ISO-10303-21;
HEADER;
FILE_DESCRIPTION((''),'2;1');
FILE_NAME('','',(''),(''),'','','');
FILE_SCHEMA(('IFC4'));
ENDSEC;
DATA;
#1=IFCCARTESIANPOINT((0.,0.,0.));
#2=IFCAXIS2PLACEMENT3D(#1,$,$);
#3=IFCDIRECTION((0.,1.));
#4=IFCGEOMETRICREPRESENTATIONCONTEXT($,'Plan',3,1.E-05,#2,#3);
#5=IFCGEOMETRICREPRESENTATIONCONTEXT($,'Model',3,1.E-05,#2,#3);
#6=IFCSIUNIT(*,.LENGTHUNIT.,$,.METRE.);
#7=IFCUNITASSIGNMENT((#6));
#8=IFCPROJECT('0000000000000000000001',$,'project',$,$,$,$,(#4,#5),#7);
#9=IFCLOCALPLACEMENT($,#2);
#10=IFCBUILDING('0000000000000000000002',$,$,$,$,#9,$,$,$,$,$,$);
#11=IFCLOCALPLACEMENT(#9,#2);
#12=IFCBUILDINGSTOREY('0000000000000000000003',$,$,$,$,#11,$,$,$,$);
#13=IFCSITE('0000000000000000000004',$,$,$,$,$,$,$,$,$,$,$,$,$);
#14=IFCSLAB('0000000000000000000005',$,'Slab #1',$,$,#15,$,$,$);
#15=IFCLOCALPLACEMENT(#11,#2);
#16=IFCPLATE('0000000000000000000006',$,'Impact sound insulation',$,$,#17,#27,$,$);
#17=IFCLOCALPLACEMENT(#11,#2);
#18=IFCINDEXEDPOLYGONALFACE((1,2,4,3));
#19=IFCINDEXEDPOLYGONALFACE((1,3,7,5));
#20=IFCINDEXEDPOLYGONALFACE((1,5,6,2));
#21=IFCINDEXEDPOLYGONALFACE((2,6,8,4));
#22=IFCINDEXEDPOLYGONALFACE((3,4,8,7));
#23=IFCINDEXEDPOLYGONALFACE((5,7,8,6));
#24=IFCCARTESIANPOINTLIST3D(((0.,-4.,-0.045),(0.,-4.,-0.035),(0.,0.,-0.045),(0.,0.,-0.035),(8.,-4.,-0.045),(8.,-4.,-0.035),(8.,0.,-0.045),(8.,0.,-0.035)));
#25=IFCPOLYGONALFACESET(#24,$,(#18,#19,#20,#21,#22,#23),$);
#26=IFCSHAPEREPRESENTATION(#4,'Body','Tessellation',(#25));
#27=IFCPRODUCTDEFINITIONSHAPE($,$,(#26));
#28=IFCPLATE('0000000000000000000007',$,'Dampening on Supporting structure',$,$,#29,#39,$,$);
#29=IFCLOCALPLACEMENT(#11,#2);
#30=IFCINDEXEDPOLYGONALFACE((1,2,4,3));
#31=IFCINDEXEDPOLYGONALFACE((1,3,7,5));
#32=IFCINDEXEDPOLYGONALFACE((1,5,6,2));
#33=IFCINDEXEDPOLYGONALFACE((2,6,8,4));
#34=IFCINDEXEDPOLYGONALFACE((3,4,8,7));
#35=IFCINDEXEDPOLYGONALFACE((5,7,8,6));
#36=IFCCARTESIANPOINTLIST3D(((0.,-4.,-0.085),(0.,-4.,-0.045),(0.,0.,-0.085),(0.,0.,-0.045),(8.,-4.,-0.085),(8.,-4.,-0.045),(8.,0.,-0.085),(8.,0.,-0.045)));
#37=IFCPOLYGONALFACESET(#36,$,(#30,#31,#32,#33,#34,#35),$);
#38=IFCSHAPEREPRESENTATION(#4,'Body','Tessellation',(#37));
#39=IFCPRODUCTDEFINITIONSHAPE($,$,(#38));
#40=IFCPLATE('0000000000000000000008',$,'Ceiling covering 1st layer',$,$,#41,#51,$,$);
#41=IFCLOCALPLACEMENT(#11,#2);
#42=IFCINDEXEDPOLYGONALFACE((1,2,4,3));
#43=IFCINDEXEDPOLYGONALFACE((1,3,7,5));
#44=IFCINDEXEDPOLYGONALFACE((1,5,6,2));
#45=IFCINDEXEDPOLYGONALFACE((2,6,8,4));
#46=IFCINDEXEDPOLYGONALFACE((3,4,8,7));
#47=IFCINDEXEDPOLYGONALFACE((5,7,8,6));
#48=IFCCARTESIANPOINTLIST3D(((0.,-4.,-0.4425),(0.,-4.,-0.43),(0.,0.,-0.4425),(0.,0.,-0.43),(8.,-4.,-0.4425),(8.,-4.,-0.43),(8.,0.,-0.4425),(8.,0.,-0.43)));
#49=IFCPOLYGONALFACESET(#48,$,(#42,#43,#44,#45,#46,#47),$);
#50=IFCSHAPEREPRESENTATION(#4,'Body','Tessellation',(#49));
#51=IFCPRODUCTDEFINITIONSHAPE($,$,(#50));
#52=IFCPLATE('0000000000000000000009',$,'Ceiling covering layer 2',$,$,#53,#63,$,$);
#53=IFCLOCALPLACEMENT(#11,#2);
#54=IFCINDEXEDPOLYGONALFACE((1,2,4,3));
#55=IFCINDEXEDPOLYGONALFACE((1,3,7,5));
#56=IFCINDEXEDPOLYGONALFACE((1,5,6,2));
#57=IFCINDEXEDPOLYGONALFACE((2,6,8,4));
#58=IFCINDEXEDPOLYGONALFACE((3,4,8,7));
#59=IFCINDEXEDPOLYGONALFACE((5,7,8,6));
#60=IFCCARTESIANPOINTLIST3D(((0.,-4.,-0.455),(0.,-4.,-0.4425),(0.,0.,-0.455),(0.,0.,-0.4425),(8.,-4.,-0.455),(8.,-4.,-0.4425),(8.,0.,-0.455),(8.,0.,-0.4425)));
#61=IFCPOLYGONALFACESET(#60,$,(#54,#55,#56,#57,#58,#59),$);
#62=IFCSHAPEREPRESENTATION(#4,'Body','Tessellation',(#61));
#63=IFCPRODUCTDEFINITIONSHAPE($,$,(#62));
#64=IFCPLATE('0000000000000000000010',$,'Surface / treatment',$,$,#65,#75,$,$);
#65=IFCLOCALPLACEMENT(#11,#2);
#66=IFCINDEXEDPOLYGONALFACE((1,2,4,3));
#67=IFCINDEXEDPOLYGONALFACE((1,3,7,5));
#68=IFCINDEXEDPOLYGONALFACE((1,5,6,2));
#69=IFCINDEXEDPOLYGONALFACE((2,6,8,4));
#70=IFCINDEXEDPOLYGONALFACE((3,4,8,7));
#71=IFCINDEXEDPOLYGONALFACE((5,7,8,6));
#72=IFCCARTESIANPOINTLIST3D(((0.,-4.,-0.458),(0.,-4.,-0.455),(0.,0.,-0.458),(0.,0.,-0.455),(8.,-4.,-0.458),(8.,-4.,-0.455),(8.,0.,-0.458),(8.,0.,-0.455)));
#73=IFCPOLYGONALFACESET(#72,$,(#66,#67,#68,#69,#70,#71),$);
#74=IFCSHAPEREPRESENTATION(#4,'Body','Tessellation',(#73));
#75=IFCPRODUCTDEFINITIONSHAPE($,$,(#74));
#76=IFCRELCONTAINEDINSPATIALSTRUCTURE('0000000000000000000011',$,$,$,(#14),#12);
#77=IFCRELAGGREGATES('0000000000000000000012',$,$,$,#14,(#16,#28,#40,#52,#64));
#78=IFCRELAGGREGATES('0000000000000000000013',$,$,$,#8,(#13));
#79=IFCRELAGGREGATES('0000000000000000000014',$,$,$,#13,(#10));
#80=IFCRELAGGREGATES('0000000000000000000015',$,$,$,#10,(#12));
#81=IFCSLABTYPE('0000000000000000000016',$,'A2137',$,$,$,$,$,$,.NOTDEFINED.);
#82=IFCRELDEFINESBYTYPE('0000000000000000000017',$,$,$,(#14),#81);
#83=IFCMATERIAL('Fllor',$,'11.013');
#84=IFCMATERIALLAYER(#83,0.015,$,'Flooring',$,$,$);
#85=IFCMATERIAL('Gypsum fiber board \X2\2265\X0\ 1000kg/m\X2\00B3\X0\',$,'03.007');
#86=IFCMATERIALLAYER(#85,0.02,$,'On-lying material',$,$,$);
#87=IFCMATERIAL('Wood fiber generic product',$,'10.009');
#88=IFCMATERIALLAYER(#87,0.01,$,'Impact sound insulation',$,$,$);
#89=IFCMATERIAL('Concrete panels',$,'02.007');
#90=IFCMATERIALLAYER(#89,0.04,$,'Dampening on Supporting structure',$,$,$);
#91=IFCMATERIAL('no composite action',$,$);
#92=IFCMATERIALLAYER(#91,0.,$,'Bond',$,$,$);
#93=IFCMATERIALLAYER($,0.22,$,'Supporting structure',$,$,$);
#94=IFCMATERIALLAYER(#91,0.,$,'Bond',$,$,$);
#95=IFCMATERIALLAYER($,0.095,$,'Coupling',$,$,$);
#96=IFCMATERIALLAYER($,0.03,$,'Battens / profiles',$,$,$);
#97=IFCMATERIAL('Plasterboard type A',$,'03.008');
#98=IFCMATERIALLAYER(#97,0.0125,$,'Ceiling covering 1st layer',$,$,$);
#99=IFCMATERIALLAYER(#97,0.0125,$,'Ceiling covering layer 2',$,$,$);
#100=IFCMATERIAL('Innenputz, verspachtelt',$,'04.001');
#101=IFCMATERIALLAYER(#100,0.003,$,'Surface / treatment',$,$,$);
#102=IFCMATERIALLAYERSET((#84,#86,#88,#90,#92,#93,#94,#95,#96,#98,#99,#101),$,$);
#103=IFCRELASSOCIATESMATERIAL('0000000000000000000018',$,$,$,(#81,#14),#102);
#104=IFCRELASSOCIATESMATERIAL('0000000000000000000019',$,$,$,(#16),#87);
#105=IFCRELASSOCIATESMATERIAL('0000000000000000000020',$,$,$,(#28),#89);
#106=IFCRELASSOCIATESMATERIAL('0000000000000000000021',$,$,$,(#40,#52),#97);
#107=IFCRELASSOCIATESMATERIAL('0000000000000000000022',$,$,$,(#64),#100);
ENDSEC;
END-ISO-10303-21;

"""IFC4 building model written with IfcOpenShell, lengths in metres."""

from ifc_helpers import new_model, si_unit, direction, frame, frame_2d, origin, place, context, project, spatial, rectangle, extrude, material, layer, layer_set, type_object, element, aggregate, save


model = new_model("IFC4")

# Units and contexts
plan_context = context("Plan", 3, precision=1e-05, world=origin(), true_north=direction((0.0, 1.0)))
model_context = context("Model", 3, precision=1e-05, world=origin(), true_north=direction((0.0, 1.0)))
ifc_project = project(units=[si_unit("LENGTHUNIT", "METRE")], contexts=[plan_context, model_context])

# Site, building, storey
site = spatial("IfcSite", under=ifc_project)
building_placement = place(None, origin())
building = spatial("IfcBuilding", under=site, at=building_placement)
storey_placement = place(building_placement, origin())
storey = spatial("IfcBuildingStorey", under=building, at=storey_placement)

# Slab, plates
ifc_material_1 = material(Name="Fllor", Category="11.013")
ifc_layer_1 = layer(ifc_material_1, 0.015, Name="Flooring")
ifc_material_2 = material(Name="Gypsum fiber board ≥ 1000kg/m³", Category="03.007")
ifc_layer_2 = layer(ifc_material_2, 0.02, Name="On-lying material")
ifc_material_3 = material(Name="Wood fiber generic product", Category="10.009")
ifc_layer_3 = layer(ifc_material_3, 0.01, Name="Impact sound insulation")
ifc_material_4 = material(Name="Concrete panels", Category="02.007")
ifc_layer_4 = layer(ifc_material_4, 0.04, Name="Dampening on Supporting structure")
ifc_material_5 = material(Name="no composite action")
ifc_layer_5 = layer(ifc_material_5, 0.0, Name="Bond")
ifc_layer_6 = layer(None, 0.22, Name="Supporting structure")
ifc_layer_7 = layer(ifc_material_5, 0.0, Name="Bond")
ifc_layer_8 = layer(None, 0.095, Name="Coupling")
ifc_layer_9 = layer(None, 0.03, Name="Battens / profiles")
ifc_material_6 = material(Name="Plasterboard type A", Category="03.008")
ifc_layer_10 = layer(ifc_material_6, 0.0125, Name="Ceiling covering 1st layer")
ifc_layer_11 = layer(ifc_material_6, 0.0125, Name="Ceiling covering layer 2")
ifc_material_7 = material(Name="Innenputz, verspachtelt", Category="04.001")
ifc_layer_12 = layer(ifc_material_7, 0.003, Name="Surface / treatment")
ifc_layer_set = layer_set([ifc_layer_1, ifc_layer_2, ifc_layer_3, ifc_layer_4, ifc_layer_5, ifc_layer_6, ifc_layer_7, ifc_layer_8, ifc_layer_9, ifc_layer_10, ifc_layer_11, ifc_layer_12])
slab_type = type_object("IfcSlabType", Name="A2137", PredefinedType="NOTDEFINED", material=ifc_layer_set)
slab_placement = place(None, frame((0.0, 0.0, 0.0), z_axis=(0.0, 0.0, -1.0), x_axis=(1.0, 0.0, 0.0)))
slab = element("IfcSlab", 1, at=slab_placement, inside=storey, type_object=slab_type, material=ifc_layer_set, Name="Slab #1")
plate_1_placement = place(slab_placement, origin())
plate_1 = element("IfcPlate", 2, at=plate_1_placement, material=ifc_material_3, Name="Impact sound insulation", context=plan_context, shape_type="SweptSolid", body=[
    extrude(rectangle(XDim=8.0, YDim=4.0, at=frame_2d((4.0, 2.0), x_axis=(1.0, 0.0))), frame((0.0, 0.0, 0.035), z_axis=(0.0, 0.0, 1.0), x_axis=(1.0, 0.0, 0.0)), (0.0, 0.0, 1.0), 0.01),
])
plate_2_placement = place(slab_placement, origin())
plate_2 = element("IfcPlate", 3, at=plate_2_placement, material=ifc_material_4, Name="Dampening on Supporting structure", context=plan_context, shape_type="SweptSolid", body=[
    extrude(rectangle(XDim=8.0, YDim=4.0, at=frame_2d((4.0, 2.0), x_axis=(1.0, 0.0))), frame((0.0, 0.0, 0.045), z_axis=(0.0, 0.0, 1.0), x_axis=(1.0, 0.0, 0.0)), (0.0, 0.0, 1.0), 0.04),
])
plate_3_placement = place(slab_placement, origin())
plate_3 = element("IfcPlate", 4, at=plate_3_placement, material=ifc_material_6, Name="Ceiling covering 1st layer", context=plan_context, shape_type="SweptSolid", body=[
    extrude(rectangle(XDim=8.0, YDim=4.0, at=frame_2d((4.0, 2.0), x_axis=(1.0, 0.0))), frame((0.0, 0.0, 0.43), z_axis=(0.0, 0.0, 1.0), x_axis=(1.0, 0.0, 0.0)), (0.0, 0.0, 1.0), 0.0125),
])
plate_4_placement = place(slab_placement, origin())
plate_4 = element("IfcPlate", 5, at=plate_4_placement, material=ifc_material_6, Name="Ceiling covering layer 2", context=plan_context, shape_type="SweptSolid", body=[
    extrude(rectangle(XDim=8.0, YDim=4.0, at=frame_2d((4.0, 2.0), x_axis=(1.0, 0.0))), frame((0.0, 0.0, 0.4425), z_axis=(0.0, 0.0, 1.0), x_axis=(1.0, 0.0, 0.0)), (0.0, 0.0, 1.0), 0.0125),
])
plate_5_placement = place(slab_placement, origin())
plate_5 = element("IfcPlate", 6, at=plate_5_placement, material=ifc_material_7, Name="Surface / treatment", context=plan_context, shape_type="SweptSolid", body=[
    extrude(rectangle(XDim=8.0, YDim=4.0, at=frame_2d((4.0, 2.0), x_axis=(1.0, 0.0))), frame((0.0, 0.0, 0.455), z_axis=(0.0, 0.0, 1.0), x_axis=(1.0, 0.0, 0.0)), (0.0, 0.0, 1.0), 0.003),
])
aggregate(slab, [plate_1, plate_2, plate_3, plate_4, plate_5])

save(model, "model.ifc")
